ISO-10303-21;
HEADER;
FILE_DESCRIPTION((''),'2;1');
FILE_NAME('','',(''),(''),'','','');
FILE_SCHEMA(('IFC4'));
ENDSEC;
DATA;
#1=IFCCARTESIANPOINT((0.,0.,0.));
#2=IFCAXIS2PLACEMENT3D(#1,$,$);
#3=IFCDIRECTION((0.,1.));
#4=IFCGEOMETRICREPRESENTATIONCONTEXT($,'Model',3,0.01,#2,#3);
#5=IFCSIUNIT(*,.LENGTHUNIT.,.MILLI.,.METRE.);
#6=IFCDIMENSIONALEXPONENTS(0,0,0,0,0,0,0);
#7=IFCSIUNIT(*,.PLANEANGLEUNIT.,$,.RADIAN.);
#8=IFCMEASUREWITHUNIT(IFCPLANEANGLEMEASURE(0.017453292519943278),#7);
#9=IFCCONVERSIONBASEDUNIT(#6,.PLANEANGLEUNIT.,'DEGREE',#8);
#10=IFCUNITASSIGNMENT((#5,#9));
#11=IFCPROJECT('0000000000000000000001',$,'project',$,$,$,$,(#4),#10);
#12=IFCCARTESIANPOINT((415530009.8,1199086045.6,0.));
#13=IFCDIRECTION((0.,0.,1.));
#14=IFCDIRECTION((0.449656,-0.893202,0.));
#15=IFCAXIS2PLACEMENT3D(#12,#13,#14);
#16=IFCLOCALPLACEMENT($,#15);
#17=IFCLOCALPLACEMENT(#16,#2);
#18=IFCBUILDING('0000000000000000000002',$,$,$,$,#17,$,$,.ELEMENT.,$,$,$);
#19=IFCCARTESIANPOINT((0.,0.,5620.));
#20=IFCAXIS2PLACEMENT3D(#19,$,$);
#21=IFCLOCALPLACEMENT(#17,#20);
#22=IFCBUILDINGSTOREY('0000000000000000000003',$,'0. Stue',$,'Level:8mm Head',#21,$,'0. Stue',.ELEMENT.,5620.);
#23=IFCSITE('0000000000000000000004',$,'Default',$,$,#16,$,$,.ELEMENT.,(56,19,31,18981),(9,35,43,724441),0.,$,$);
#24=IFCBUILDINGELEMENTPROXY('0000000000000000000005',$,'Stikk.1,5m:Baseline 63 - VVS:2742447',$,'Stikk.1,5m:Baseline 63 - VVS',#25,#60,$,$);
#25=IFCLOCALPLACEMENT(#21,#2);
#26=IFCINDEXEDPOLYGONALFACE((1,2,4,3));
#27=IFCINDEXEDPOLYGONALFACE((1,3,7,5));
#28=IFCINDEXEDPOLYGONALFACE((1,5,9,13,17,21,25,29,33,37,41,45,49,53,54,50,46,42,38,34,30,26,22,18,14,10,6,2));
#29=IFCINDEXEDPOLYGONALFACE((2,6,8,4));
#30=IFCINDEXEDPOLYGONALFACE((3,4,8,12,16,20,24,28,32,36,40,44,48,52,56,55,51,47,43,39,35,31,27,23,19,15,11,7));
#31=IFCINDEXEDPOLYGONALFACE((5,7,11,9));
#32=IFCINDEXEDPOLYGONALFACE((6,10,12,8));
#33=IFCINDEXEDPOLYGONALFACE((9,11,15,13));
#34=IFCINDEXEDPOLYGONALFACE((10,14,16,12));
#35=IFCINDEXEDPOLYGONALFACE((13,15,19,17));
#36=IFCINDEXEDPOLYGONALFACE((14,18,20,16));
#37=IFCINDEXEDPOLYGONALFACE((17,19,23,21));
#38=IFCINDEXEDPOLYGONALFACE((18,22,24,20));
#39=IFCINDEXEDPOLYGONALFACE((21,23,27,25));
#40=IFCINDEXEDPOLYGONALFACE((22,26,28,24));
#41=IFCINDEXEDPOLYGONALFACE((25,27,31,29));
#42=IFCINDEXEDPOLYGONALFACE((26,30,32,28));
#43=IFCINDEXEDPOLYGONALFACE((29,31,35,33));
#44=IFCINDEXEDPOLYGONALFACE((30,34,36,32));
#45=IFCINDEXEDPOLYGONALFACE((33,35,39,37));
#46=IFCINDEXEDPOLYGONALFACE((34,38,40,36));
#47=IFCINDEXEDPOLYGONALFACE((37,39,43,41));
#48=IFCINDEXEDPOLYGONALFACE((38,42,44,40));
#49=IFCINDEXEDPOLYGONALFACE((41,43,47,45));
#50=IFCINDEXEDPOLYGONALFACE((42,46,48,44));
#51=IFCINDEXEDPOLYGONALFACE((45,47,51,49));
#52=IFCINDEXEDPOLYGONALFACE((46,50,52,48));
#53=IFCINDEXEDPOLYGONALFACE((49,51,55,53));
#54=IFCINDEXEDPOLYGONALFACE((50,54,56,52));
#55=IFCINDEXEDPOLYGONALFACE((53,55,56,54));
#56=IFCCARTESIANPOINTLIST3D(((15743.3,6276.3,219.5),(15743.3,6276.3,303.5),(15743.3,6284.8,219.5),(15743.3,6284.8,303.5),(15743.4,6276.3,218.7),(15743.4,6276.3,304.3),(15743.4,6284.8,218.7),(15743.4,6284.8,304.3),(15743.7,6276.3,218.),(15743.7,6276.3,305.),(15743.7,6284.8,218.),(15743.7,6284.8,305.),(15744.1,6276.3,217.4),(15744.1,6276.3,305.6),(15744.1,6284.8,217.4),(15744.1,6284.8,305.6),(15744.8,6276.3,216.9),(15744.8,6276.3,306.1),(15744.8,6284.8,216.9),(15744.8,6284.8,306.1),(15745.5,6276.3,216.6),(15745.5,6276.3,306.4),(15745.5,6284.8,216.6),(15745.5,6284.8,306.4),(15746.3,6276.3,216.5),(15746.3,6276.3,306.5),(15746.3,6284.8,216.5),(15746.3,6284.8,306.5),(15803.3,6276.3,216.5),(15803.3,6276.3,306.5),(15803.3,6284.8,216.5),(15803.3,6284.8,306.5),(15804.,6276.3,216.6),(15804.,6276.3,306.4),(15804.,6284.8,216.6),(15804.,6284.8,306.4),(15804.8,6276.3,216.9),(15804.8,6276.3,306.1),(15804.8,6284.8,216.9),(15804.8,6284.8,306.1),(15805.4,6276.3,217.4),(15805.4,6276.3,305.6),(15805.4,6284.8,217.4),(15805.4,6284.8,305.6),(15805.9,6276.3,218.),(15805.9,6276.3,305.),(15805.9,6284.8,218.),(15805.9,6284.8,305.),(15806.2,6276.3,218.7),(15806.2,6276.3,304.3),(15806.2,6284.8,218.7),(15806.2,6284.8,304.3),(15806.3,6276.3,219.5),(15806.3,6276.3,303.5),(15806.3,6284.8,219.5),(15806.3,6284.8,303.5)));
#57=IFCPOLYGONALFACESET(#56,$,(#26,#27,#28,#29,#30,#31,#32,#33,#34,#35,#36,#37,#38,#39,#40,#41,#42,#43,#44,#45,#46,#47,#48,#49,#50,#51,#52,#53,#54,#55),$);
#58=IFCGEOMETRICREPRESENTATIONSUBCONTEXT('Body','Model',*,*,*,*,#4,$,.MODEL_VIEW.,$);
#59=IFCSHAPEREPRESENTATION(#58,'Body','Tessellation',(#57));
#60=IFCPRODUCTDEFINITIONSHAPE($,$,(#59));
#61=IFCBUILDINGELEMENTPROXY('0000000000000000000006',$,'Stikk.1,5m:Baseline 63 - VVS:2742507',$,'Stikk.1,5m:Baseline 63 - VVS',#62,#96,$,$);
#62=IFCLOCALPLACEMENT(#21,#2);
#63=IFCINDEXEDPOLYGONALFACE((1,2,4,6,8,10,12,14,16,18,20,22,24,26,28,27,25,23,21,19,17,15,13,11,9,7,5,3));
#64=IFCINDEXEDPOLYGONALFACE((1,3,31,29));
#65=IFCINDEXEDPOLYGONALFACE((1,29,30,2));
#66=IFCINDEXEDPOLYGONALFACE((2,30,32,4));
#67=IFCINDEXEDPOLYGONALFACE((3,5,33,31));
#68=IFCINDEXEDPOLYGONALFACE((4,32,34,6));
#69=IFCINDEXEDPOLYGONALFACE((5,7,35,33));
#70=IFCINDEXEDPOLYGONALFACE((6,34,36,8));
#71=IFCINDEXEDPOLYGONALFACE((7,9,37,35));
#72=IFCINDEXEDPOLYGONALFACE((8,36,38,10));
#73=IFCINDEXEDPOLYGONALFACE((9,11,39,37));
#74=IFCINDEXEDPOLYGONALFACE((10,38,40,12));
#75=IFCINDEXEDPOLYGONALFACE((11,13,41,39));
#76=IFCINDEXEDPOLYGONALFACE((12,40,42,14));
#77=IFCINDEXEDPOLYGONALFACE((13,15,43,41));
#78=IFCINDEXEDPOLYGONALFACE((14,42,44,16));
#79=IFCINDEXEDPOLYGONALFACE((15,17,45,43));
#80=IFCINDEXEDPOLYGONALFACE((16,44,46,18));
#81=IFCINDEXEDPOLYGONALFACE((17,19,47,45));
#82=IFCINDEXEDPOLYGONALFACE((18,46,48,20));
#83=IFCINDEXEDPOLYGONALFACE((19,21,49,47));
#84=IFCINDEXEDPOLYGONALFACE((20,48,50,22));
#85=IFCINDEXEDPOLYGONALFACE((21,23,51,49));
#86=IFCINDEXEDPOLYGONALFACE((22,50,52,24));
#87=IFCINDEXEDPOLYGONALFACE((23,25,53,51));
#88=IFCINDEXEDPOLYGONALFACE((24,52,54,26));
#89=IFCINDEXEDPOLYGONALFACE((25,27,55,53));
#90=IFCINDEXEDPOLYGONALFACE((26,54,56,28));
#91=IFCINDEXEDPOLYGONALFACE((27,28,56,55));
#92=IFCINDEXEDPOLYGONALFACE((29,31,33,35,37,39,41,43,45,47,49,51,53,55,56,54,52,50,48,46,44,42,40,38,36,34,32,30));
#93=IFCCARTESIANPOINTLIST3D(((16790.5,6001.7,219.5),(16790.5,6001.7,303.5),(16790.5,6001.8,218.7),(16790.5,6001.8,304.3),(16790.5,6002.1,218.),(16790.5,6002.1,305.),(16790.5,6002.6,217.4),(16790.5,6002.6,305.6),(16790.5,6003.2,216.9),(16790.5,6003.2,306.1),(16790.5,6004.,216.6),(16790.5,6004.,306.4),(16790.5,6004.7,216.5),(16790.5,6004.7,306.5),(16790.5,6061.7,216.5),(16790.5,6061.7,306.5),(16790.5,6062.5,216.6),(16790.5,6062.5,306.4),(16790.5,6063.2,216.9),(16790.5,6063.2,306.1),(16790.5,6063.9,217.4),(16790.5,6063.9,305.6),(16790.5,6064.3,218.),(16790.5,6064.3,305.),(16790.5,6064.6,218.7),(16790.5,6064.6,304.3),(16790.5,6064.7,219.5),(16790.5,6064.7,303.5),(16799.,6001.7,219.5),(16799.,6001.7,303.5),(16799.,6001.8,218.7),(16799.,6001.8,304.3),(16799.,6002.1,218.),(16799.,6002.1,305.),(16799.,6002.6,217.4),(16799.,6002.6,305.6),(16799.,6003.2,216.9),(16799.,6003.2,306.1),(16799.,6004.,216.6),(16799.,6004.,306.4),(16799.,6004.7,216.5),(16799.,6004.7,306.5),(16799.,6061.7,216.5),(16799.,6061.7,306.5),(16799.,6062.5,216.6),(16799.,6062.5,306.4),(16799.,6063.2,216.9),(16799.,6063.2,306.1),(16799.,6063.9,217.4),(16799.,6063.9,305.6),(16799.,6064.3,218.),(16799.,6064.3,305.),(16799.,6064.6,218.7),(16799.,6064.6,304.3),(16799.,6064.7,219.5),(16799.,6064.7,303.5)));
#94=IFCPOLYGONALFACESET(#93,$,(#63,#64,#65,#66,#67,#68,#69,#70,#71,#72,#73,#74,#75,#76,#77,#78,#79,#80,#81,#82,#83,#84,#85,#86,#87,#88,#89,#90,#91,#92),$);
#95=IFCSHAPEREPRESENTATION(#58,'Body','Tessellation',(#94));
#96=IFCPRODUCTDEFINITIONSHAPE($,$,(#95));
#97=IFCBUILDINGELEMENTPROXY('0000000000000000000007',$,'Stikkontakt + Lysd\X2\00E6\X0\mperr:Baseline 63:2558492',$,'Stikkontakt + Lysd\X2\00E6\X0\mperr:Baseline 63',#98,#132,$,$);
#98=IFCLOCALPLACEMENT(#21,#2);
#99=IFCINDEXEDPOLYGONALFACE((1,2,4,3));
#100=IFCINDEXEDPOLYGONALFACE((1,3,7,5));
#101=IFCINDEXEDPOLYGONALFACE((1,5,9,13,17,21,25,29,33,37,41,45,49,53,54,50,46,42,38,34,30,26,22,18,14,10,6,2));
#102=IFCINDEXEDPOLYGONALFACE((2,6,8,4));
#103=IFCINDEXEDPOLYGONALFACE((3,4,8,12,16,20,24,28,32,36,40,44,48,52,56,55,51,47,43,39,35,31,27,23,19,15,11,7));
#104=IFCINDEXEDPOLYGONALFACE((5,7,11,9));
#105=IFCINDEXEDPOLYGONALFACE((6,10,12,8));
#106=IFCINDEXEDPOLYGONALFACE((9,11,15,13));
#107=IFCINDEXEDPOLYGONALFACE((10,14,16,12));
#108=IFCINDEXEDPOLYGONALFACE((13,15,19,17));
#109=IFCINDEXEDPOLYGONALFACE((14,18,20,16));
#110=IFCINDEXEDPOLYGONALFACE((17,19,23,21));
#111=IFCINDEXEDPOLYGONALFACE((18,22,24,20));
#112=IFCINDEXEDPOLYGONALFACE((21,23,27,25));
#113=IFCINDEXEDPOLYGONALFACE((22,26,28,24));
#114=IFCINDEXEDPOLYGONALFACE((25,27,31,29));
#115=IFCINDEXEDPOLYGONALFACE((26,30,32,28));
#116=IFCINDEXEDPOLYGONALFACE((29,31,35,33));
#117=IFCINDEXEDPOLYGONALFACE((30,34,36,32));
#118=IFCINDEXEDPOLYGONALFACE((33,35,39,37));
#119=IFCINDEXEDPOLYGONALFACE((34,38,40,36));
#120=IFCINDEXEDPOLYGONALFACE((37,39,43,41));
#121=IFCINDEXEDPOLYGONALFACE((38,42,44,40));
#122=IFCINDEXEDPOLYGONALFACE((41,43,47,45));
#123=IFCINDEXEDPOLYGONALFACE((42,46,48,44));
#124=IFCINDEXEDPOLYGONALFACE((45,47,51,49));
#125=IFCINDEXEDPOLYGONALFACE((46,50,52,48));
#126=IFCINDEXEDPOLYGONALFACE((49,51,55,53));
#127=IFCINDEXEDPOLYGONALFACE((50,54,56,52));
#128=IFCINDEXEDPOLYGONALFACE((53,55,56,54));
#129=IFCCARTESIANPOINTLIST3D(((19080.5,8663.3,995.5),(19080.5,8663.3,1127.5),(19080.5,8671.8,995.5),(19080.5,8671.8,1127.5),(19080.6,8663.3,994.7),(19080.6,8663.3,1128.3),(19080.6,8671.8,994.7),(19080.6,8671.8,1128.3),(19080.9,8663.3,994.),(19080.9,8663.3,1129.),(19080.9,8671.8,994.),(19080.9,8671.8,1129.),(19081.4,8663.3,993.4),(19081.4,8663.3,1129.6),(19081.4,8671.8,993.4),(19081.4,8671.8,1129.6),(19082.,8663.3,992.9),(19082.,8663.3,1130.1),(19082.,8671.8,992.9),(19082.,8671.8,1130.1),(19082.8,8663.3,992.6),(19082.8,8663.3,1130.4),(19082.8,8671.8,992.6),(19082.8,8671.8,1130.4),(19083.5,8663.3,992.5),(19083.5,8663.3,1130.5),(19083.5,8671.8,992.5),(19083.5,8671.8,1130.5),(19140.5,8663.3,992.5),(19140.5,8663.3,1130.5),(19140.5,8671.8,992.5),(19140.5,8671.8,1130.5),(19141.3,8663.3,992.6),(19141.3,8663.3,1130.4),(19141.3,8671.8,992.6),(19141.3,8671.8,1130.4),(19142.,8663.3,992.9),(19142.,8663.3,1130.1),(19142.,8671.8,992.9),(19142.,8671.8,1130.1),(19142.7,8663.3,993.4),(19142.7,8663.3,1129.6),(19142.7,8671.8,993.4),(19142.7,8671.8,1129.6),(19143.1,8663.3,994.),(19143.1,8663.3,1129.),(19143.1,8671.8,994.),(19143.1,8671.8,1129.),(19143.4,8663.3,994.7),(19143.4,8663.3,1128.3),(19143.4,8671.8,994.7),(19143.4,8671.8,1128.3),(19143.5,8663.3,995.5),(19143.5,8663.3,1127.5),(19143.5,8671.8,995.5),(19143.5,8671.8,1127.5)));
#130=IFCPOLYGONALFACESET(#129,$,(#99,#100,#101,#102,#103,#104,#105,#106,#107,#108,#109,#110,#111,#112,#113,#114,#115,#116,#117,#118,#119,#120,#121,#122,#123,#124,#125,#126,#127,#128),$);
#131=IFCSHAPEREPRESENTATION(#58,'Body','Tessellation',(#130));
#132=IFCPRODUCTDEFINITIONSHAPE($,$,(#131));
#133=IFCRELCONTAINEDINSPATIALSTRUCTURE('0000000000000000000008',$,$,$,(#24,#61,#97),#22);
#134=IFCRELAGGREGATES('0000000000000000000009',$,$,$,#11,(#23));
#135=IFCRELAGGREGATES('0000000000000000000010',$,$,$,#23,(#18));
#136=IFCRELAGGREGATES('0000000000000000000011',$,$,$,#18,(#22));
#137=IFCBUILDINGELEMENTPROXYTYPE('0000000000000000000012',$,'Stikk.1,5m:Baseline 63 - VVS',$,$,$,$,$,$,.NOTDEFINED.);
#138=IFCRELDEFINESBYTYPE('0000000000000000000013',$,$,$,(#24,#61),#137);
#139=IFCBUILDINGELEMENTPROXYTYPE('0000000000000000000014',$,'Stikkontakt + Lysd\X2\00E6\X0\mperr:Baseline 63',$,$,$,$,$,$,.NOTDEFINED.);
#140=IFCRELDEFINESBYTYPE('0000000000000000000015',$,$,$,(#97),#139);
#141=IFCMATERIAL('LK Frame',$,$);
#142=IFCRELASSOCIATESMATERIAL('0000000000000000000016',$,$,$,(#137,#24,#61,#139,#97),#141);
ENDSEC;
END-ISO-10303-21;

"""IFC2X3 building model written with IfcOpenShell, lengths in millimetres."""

from ifc_helpers import new_model, entity, si_unit, converted_unit, direction, frame, frame_2d, origin, place, context, subcontext, project, spatial, polyline, circle_curve, parameter, trimmed, segment, composite_curve, outline, extrude, source, transform, mapped, material, type_object, type_shapes, element, save


model = new_model("IFC2X3")

# Units and contexts
model_context = context("Model", 3, precision=0.01, world=origin(), true_north=direction((0.0, 1.0)))
body_context = subcontext(model_context, "Body", "Model", "MODEL_VIEW")
ifc_project = project(units=[si_unit("LENGTHUNIT", "METRE", prefix="MILLI"), converted_unit("PLANEANGLEUNIT", "DEGREE", entity("IfcPlaneAngleMeasure", 0.017453292519943278), si_unit("PLANEANGLEUNIT", "RADIAN"), dimensions=[0, 0, 0, 0, 0, 0, 0])], contexts=[model_context])

# Site, building, storey
site_placement = place(None, frame((415530009.8, 1199086045.6, 0.0), z_axis=(0.0, 0.0, 1.0), x_axis=(0.449656, -0.893202, 0.0)))
site = spatial("IfcSite", under=ifc_project, at=site_placement, Name="Default", CompositionType="ELEMENT", RefLatitude=(56, 19, 31, 18981), RefLongitude=(9, 35, 43, 724441), RefElevation=0.0)
building_placement = place(site_placement, origin())
building = spatial("IfcBuilding", under=site, at=building_placement, CompositionType="ELEMENT")
storey_placement = place(building_placement, frame((0.0, 0.0, 5620.0)))
storey = spatial("IfcBuildingStorey", under=building, at=storey_placement, Name="0. Stue", ObjectType="Level:8mm Head", LongName="0. Stue", CompositionType="ELEMENT", Elevation=5620.0)

# Building element proxies
ifc_material_1 = material(Name="LK Frame")
building_element_proxy_type_1 = type_object("IfcBuildingElementProxyType", Name="Stikk.1,5m:Baseline 63 - VVS", PredefinedType="NOTDEFINED", material=ifc_material_1)
shared_shape_1 = source(origin(), body_context, "Body", "SweptSolid", [
    extrude(outline(composite_curve([segment(polyline([(-42.0, -31.5), (42.0, -31.5)]), True, "CONTINUOUS"), segment(trimmed(circle_curve(frame_2d((42.0, -28.5), x_axis=(-1.0, 0.0)), 3.0), [parameter(90.0)], [parameter(180.0)], True, "PARAMETER"), True, "CONTINUOUS"), segment(polyline([(45.0, -28.5), (45.0, 28.5)]), True, "CONTINUOUS"), segment(trimmed(circle_curve(frame_2d((42.0, 28.5), x_axis=(-1.0, 0.0)), 3.0), [parameter(180.0)], [parameter(270.0)], True, "PARAMETER"), True, "CONTINUOUS"), segment(polyline([(42.0, 31.5), (-42.0, 31.5)]), True, "CONTINUOUS"), segment(trimmed(circle_curve(frame_2d((-42.0, 28.5), x_axis=(1.0, 0.0)), 3.0), [parameter(90.0)], [parameter(180.0)], True, "PARAMETER"), True, "CONTINUOUS"), segment(polyline([(-45.0, 28.5), (-45.0, -28.5)]), True, "CONTINUOUS"), segment(trimmed(circle_curve(frame_2d((-42.0, -28.5), x_axis=(1.0, 0.0)), 3.0), [parameter(180.0)], [parameter(270.0)], True, "PARAMETER"), True, "CONTINUOUS")], self_intersect=False)), frame((0.0, -38.5, 0.0), z_axis=(0.0, 0.0, 1.0), x_axis=(0.0, 1.0, 0.0)), (0.0, 0.0, 1.0), 8.5),
])
type_shapes(building_element_proxy_type_1, [shared_shape_1])
for number, where, z_axis, x_axis, name in (
    (1, (15774.8, 6276.3, 300.0), (0.0, 1.0, 0.0), (-1.0, 0.0, 0.0), "Stikk.1,5m:Baseline 63 - VVS:2742447"),
    (2, (16790.5, 6033.2, 300.0), (1.0, 0.0, 0.0), (0.0, 1.0, 0.0), "Stikk.1,5m:Baseline 63 - VVS:2742507"),
):
    element("IfcBuildingElementProxy", number, at=place(storey_placement, frame(where, z_axis=z_axis, x_axis=x_axis)), inside=storey, type_object=building_element_proxy_type_1, material=ifc_material_1, Name=name, ObjectType="Stikk.1,5m:Baseline 63 - VVS", context=body_context, shape_type="MappedRepresentation", body=[
        mapped(shared_shape_1, transform((0.0, 0.0, 0.0), scale=1.0)),
    ])
building_element_proxy_type_2 = type_object("IfcBuildingElementProxyType", Name="Stikkontakt + Lysdæmperr:Baseline 63", PredefinedType="NOTDEFINED", material=ifc_material_1)
shared_shape_2 = source(origin(), body_context, "Body", "SweptSolid", [
    extrude(outline(composite_curve([segment(polyline([(-66.0, -31.5), (66.0, -31.5)]), True, "CONTINUOUS"), segment(trimmed(circle_curve(frame_2d((66.0, -28.5), x_axis=(-1.0, 0.0)), 3.0), [parameter(90.0)], [parameter(180.0)], True, "PARAMETER"), True, "CONTINUOUS"), segment(polyline([(69.0, -28.5), (69.0, 28.5)]), True, "CONTINUOUS"), segment(trimmed(circle_curve(frame_2d((66.0, 28.5), x_axis=(-1.0, 0.0)), 3.0), [parameter(180.0)], [parameter(270.0)], True, "PARAMETER"), True, "CONTINUOUS"), segment(polyline([(66.0, 31.5), (-66.0, 31.5)]), True, "CONTINUOUS"), segment(trimmed(circle_curve(frame_2d((-66.0, 28.5), x_axis=(1.0, 0.0)), 3.0), [parameter(90.0)], [parameter(180.0)], True, "PARAMETER"), True, "CONTINUOUS"), segment(polyline([(-69.0, 28.5), (-69.0, -28.5)]), True, "CONTINUOUS"), segment(trimmed(circle_curve(frame_2d((-66.0, -28.5), x_axis=(1.0, 0.0)), 3.0), [parameter(180.0)], [parameter(270.0)], True, "PARAMETER"), True, "CONTINUOUS")], self_intersect=False)), frame((0.0, -38.5, 0.0), z_axis=(0.0, 0.0, 1.0), x_axis=(0.0, 1.0, 0.0)), (0.0, 0.0, 1.0), 8.5),
])
type_shapes(building_element_proxy_type_2, [shared_shape_2])
proxy_1_placement = place(storey_placement, frame((19112.0, 8663.3, 1100.0), z_axis=(0.0, 1.0, 0.0), x_axis=(-1.0, 0.0, 0.0)))
element("IfcBuildingElementProxy", 3, at=proxy_1_placement, inside=storey, type_object=building_element_proxy_type_2, material=ifc_material_1, Name="Stikkontakt + Lysdæmperr:Baseline 63:2558492", ObjectType="Stikkontakt + Lysdæmperr:Baseline 63", context=body_context, shape_type="MappedRepresentation", body=[
    mapped(shared_shape_2, transform((0.0, 0.0, 0.0), scale=1.0)),
])

save(model, "model.ifc")
